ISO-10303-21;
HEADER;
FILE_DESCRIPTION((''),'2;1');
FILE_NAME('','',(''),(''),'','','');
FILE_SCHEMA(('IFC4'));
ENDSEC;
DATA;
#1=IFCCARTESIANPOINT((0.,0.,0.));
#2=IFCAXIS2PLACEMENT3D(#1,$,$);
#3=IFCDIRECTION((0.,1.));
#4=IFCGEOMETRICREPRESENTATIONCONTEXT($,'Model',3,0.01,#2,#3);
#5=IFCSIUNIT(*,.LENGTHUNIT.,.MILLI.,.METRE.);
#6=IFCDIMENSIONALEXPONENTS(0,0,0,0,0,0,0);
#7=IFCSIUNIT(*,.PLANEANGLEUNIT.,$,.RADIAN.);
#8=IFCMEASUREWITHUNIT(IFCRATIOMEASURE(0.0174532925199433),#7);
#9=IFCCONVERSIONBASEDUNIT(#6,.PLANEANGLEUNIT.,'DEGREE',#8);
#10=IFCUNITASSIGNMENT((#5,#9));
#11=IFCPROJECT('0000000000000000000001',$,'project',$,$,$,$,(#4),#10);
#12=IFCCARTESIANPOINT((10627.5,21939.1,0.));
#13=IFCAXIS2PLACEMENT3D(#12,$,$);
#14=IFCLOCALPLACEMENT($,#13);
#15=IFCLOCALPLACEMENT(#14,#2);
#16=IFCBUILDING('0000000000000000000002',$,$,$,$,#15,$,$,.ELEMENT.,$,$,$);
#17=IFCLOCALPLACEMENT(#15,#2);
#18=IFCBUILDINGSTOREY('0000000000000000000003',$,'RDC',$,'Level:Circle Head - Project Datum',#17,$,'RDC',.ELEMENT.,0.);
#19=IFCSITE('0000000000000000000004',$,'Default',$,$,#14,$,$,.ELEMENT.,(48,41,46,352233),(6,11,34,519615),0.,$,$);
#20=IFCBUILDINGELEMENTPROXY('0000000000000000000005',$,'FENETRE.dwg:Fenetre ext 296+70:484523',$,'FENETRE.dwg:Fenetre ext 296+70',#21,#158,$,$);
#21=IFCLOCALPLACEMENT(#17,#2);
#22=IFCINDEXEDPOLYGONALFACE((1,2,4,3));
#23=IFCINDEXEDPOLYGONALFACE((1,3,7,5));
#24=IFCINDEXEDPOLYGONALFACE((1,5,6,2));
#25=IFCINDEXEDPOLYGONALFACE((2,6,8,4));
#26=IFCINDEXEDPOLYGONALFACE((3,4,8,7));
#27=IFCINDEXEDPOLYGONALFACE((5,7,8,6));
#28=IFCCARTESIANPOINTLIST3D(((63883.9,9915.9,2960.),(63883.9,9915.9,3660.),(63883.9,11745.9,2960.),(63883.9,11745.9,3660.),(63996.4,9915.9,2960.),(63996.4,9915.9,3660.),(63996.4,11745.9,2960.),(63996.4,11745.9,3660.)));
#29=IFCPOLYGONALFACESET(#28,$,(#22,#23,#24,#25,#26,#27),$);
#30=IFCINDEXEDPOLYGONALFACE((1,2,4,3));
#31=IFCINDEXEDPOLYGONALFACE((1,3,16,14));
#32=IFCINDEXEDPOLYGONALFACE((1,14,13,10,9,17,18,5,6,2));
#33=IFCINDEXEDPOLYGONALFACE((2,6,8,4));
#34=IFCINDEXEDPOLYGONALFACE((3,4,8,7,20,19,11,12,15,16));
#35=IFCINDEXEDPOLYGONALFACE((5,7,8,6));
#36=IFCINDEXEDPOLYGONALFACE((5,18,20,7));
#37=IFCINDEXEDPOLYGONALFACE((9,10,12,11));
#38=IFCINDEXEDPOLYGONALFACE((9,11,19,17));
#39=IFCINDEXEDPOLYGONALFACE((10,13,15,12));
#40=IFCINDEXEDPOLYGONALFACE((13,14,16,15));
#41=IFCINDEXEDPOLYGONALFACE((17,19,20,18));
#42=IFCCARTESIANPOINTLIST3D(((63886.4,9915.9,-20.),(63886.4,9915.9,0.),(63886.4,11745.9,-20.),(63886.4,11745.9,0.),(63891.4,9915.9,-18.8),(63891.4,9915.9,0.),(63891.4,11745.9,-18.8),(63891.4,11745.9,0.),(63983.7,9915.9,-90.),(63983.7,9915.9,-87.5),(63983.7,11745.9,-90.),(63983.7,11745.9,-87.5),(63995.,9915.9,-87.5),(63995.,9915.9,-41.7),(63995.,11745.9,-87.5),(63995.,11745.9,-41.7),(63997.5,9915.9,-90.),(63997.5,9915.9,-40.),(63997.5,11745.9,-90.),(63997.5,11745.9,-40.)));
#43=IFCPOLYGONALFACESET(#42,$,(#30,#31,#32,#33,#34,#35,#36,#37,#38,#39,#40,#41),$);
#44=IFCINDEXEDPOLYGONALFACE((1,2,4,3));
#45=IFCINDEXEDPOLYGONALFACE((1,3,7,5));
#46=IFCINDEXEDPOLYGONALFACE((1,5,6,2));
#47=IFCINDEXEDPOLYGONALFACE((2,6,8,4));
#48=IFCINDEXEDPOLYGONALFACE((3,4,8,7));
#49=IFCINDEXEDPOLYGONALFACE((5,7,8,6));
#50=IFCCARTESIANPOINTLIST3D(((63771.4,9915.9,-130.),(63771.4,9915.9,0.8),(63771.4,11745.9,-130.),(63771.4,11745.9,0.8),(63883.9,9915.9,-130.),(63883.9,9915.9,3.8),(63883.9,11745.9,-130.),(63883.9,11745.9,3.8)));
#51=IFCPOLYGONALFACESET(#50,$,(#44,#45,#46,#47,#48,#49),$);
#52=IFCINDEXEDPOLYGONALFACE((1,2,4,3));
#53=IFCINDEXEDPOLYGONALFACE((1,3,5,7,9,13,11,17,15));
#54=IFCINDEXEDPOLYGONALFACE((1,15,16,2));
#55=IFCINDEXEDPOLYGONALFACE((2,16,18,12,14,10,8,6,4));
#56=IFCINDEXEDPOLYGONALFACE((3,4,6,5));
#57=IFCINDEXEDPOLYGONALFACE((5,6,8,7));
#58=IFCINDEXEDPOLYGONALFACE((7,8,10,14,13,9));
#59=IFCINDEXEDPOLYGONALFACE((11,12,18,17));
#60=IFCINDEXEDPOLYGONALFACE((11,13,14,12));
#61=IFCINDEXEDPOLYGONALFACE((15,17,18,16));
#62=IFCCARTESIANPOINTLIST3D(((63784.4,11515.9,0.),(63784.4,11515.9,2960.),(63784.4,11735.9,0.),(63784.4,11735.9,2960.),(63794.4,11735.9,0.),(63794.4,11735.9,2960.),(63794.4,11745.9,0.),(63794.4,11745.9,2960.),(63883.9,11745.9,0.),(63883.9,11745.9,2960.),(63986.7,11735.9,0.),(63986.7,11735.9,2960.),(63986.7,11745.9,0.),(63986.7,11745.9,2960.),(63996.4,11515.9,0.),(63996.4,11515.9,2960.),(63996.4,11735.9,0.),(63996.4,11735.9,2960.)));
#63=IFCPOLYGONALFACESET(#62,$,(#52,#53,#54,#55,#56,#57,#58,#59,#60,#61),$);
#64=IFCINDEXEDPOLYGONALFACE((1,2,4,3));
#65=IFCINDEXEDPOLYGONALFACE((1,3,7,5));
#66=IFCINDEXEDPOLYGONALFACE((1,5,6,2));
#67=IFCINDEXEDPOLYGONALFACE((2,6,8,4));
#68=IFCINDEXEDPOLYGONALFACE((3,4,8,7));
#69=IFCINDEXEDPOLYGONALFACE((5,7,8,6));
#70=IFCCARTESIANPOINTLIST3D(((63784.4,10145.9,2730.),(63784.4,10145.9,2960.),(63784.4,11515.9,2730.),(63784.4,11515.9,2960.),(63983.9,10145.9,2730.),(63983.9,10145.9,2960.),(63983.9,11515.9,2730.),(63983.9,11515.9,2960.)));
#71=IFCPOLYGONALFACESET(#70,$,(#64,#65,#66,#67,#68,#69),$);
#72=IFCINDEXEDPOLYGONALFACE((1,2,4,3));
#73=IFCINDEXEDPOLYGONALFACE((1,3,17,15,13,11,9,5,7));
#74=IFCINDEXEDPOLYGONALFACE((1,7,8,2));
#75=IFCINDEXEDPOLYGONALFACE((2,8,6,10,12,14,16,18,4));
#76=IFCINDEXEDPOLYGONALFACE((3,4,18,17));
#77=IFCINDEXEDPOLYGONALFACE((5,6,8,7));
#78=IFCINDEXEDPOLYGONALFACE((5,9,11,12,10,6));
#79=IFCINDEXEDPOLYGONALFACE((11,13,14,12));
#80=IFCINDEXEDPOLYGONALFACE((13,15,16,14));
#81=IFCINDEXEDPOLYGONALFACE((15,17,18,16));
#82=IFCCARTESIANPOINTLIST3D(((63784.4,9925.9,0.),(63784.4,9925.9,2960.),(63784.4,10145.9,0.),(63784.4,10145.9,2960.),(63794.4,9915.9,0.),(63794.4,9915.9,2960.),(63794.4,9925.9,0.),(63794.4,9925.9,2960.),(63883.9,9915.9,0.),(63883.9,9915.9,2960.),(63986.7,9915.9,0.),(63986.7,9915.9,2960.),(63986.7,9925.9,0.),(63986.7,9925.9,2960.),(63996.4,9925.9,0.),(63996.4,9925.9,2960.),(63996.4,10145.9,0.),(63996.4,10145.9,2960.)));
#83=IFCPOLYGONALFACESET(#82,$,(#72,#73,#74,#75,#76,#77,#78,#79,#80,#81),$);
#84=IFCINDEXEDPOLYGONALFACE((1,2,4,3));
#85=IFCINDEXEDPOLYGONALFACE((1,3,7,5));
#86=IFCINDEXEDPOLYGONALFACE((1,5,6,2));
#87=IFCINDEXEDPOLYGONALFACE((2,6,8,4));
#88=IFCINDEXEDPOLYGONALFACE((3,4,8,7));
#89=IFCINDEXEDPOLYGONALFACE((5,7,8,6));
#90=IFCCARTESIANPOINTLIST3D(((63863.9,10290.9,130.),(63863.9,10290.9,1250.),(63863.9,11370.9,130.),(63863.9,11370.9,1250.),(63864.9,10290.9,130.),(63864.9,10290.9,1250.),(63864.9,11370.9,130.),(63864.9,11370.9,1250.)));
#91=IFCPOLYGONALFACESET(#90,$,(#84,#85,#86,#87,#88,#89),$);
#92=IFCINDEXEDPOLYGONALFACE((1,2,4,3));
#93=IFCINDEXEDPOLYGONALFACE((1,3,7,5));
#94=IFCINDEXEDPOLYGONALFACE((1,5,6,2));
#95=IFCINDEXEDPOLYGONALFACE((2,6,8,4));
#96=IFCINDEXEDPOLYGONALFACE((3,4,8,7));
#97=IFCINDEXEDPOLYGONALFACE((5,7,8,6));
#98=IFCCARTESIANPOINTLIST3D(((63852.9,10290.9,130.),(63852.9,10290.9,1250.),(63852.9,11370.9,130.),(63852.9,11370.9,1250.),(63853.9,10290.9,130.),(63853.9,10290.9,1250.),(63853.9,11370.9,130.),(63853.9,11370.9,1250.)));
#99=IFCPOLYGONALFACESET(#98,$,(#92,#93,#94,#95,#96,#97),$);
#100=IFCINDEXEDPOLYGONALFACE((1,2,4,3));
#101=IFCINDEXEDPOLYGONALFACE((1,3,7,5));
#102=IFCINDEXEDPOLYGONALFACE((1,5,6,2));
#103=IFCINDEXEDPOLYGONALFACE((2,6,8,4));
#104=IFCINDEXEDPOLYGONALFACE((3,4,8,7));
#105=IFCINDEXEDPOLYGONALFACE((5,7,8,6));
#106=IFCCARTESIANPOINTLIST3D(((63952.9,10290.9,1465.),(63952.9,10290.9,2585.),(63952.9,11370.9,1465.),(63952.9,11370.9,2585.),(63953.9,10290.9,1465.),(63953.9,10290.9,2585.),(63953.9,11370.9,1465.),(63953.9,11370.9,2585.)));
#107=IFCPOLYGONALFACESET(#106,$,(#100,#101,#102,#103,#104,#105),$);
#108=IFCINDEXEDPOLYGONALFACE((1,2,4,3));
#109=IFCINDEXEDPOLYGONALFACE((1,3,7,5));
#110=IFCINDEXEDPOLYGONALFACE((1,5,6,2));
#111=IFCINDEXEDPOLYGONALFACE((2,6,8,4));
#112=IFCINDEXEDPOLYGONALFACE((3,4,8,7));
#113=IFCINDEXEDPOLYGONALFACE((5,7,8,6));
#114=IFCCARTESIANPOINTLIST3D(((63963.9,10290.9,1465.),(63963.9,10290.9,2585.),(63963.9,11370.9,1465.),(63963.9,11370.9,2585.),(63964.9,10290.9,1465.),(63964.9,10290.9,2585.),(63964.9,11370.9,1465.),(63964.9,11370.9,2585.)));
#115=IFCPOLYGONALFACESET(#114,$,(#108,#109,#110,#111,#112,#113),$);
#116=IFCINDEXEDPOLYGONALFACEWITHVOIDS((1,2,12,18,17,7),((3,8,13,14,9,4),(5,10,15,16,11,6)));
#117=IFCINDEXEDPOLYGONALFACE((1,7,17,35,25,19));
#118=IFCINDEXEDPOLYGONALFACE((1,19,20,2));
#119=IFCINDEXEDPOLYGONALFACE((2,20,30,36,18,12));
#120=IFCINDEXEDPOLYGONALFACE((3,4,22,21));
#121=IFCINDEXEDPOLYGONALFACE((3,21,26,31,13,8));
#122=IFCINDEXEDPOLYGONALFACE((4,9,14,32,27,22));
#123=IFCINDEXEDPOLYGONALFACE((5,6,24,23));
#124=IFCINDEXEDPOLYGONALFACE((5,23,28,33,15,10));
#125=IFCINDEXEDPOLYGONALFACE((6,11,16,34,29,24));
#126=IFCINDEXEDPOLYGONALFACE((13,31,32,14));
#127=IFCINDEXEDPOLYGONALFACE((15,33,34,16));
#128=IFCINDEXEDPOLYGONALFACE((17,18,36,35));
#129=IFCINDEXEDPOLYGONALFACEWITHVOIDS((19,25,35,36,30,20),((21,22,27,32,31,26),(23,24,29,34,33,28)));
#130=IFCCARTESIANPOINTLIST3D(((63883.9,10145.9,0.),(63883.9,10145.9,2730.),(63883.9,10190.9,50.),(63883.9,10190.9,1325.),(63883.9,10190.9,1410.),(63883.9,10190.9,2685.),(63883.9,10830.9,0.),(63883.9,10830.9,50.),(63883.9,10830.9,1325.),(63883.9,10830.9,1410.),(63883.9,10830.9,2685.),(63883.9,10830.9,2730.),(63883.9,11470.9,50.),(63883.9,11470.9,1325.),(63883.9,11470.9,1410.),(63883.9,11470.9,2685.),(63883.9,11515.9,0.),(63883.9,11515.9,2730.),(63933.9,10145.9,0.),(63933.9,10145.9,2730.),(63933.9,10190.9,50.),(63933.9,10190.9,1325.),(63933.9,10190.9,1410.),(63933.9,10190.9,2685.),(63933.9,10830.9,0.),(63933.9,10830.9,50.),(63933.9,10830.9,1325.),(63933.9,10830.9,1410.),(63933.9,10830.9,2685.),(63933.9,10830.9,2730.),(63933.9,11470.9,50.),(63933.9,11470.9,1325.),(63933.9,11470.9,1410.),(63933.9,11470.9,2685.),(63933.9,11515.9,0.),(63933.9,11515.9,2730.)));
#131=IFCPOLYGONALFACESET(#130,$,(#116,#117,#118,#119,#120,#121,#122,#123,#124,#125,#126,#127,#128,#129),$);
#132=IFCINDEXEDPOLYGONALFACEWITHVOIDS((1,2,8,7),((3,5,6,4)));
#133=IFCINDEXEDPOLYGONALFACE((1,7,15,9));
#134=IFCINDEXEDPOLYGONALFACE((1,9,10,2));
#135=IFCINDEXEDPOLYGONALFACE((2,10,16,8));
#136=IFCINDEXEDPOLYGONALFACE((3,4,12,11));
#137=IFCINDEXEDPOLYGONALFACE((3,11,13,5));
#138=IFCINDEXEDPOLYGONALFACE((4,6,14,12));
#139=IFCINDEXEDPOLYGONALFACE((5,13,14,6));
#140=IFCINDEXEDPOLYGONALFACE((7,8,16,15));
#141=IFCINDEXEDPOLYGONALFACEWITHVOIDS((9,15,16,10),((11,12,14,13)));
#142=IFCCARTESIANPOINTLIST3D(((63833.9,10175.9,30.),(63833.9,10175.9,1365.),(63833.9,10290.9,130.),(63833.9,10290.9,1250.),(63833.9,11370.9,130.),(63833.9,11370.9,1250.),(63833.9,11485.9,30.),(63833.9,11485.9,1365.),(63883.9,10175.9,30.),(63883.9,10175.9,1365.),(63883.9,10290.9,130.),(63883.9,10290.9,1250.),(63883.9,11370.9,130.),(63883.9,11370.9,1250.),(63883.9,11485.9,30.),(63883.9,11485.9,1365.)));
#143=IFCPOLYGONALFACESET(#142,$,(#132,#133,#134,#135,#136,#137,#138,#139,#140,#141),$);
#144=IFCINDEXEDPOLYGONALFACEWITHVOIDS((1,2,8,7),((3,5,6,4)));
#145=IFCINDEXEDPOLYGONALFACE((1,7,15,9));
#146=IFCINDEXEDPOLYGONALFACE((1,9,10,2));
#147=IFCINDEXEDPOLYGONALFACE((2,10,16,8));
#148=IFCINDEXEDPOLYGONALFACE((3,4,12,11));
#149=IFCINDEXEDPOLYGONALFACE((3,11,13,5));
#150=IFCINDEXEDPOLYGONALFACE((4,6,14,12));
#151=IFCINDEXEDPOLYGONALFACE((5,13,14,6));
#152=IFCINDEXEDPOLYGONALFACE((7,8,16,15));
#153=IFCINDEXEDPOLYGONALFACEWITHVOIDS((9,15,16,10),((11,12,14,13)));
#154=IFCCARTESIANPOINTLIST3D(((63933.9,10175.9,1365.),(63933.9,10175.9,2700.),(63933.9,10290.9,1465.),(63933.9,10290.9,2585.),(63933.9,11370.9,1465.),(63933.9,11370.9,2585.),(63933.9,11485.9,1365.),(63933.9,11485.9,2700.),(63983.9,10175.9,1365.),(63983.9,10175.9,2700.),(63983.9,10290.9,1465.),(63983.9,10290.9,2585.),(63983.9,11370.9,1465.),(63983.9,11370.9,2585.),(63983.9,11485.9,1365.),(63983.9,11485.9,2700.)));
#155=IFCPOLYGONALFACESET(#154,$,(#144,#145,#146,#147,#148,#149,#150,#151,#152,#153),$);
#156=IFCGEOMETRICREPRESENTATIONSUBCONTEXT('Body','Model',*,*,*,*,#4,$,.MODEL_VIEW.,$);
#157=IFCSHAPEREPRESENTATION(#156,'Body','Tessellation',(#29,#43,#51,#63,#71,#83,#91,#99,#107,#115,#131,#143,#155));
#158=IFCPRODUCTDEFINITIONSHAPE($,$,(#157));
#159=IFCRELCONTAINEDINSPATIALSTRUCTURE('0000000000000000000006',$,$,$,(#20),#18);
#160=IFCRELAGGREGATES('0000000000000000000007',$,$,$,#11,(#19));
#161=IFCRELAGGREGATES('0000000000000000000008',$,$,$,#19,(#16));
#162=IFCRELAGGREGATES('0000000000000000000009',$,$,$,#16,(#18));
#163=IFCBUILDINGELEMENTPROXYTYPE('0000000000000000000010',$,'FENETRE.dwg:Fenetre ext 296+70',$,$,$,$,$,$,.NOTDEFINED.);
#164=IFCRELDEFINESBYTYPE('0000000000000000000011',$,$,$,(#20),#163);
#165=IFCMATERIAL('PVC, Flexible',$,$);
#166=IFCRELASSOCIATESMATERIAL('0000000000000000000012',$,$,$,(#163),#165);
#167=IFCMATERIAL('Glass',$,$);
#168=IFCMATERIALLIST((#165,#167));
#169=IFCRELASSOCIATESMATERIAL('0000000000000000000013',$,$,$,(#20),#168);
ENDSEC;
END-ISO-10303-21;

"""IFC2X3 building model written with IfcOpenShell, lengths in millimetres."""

from ifc_helpers import new_model, entity, si_unit, converted_unit, direction, frame, frame_2d, origin, origin_2d_with_axis, place, context, subcontext, project, spatial, polyline, rectangle, outline, extrude, source, transform, mapped, material, material_list, type_object, type_shapes, element, save


model = new_model("IFC2X3")

# Units and contexts
model_context = context("Model", 3, precision=0.01, world=origin(), true_north=direction((0.0, 1.0)))
body_context = subcontext(model_context, "Body", "Model", "MODEL_VIEW")
ifc_project = project(units=[si_unit("LENGTHUNIT", "METRE", prefix="MILLI"), converted_unit("PLANEANGLEUNIT", "DEGREE", entity("IfcRatioMeasure", 0.0174532925199433), si_unit("PLANEANGLEUNIT", "RADIAN"), dimensions=[0, 0, 0, 0, 0, 0, 0])], contexts=[model_context])

# Site, building, storey
site_placement = place(None, frame((10627.5, 21939.1, 0.0)))
site = spatial("IfcSite", under=ifc_project, at=site_placement, Name="Default", CompositionType="ELEMENT", RefLatitude=(48, 41, 46, 352233), RefLongitude=(6, 11, 34, 519615), RefElevation=0.0)
building_placement = place(site_placement, origin())
building = spatial("IfcBuilding", under=site, at=building_placement, CompositionType="ELEMENT")
storey_placement = place(building_placement, origin())
storey = spatial("IfcBuildingStorey", under=building, at=storey_placement, Name="RDC", ObjectType="Level:Circle Head - Project Datum", LongName="RDC", CompositionType="ELEMENT", Elevation=0.0)

# Building element proxy
ifc_material_1 = material(Name="PVC, Flexible")
ifc_material_2 = material(Name="Glass")
building_element_proxy_type_1 = type_object("IfcBuildingElementProxyType", Name="FENETRE.dwg:Fenetre ext 296+70", PredefinedType="NOTDEFINED", material=ifc_material_1)
shared_shape_1 = source(origin(), body_context, "Body", "SweptSolid", [
    extrude(rectangle(XDim=112.5, YDim=1830.0, at=origin_2d_with_axis()), frame((-10.4, -56.3, 2960.0), z_axis=(0.0, 0.0, 1.0), x_axis=(0.0, 1.0, 0.0)), (0.0, 0.0, 1.0), 700.0),
    extrude(outline(polyline([(27.5, -64.4), (47.5, -64.4), (47.5, -59.4), (28.8, -59.4), (7.5, 46.7), (-42.5, 46.7), (-42.5, 32.9), (-40.0, 32.9), (-40.0, 44.2), (5.8, 44.2), (27.5, -64.4)])), frame((-925.4, -66.9, -47.5), z_axis=(1.0, 0.0, 0.0), x_axis=(0.0, 0.0, 1.0)), (0.0, 0.0, 1.0), 1830.0),
    extrude(outline(polyline([(-54.5, -66.1), (58.0, -66.1), (54.5, 67.6), (-58.0, 64.6), (-54.5, -66.1)])), frame((-925.4, 56.3, -63.8), z_axis=(1.0, 0.0, 0.0), x_axis=(0.0, -0.999645, 0.02665)), (0.0, 0.0, 1.0), 1830.0),
    extrude(outline(polyline([(-97.0, -55.6), (5.9, -55.6), (95.4, -55.6), (95.4, -45.6), (105.4, -45.6), (105.4, 174.4), (-106.6, 174.4), (-106.6, -45.6), (-97.0, -45.6), (-97.0, -55.6)])), frame((849.0, -5.9, 0.0), z_axis=(0.0, 0.0, 1.0), x_axis=(0.0, 1.0, 0.0)), (0.0, 0.0, 1.0), 2960.0),
    extrude(rectangle(XDim=1370.0, YDim=199.5, at=origin_2d_with_axis()), frame((-10.4, -0.3, 2730.0), z_axis=(0.0, 0.0, 1.0), x_axis=(-1.0, 0.0, 0.0)), (0.0, 0.0, 1.0), 230.0),
    extrude(outline(polyline([(-55.6, 97.0), (-55.6, -5.9), (-55.6, -95.4), (-45.6, -95.4), (-45.6, -105.4), (174.4, -105.4), (174.4, 106.6), (-45.6, 106.6), (-45.6, 97.0), (-55.6, 97.0)])), frame((-869.9, -5.9, 0.0), z_axis=(0.0, 0.0, -1.0), x_axis=(1.0, 0.0, 0.0)), (0.0, 0.0, -1.0), 2960.0),
    extrude(rectangle(XDim=1080.0, YDim=1.0, at=origin_2d_with_axis()), frame((-10.4, 19.5, 130.0), z_axis=(0.0, 0.0, 1.0), x_axis=(-1.0, 0.0, 0.0)), (0.0, 0.0, 1.0), 1120.0),
    extrude(rectangle(XDim=1080.0, YDim=1.0, at=origin_2d_with_axis()), frame((-10.4, 30.5, 130.0), z_axis=(0.0, 0.0, 1.0), x_axis=(-1.0, 0.0, 0.0)), (0.0, 0.0, 1.0), 1120.0),
    extrude(rectangle(XDim=1080.0, YDim=1.0, at=frame_2d((0.0, 0.0), x_axis=(1.0, 0.0))), frame((-10.4, -69.5, 1465.0), z_axis=(0.0, 0.0, 1.0), x_axis=(-1.0, 0.0, 0.0)), (0.0, 0.0, 1.0), 1120.0),
    extrude(rectangle(XDim=1080.0, YDim=1.0, at=frame_2d((0.0, 0.0), x_axis=(1.0, 0.0))), frame((-10.4, -80.5, 1465.0), z_axis=(0.0, 0.0, 1.0), x_axis=(-1.0, 0.0, 0.0)), (0.0, 0.0, 1.0), 1120.0),
    extrude(outline(polyline([(-685.0, -1365.0), (0.0, -1365.0), (685.0, -1365.0), (685.0, 1365.0), (0.0, 1365.0), (-685.0, 1365.0), (-685.0, -1365.0)]), holes=[polyline([(-640.0, -1320.0), (-640.0, -45.0), (0.0, -45.0), (640.0, -45.0), (640.0, -1320.0), (0.0, -1320.0), (-640.0, -1320.0)]), polyline([(-640.0, 40.0), (-640.0, 1315.0), (0.0, 1315.0), (640.0, 1315.0), (640.0, 40.0), (0.0, 40.0), (-640.0, 40.0)])]), frame((-10.4, -50.0, 1365.0), z_axis=(0.0, 1.0, 0.0), x_axis=(1.0, 0.0, 0.0)), (0.0, 0.0, 1.0), 50.0),
    extrude(outline(polyline([(-655.0, -667.5), (655.0, -667.5), (655.0, 667.5), (-655.0, 667.5), (-655.0, -667.5)]), holes=[polyline([(-540.0, 552.5), (540.0, 552.5), (540.0, -567.5), (-540.0, -567.5), (-540.0, 552.5)])]), frame((-10.4, 0.0, 697.5), z_axis=(0.0, 1.0, 0.0), x_axis=(-1.0, 0.0, 0.0)), (0.0, 0.0, 1.0), 50.0),
    extrude(outline(polyline([(-655.0, -667.5), (655.0, -667.5), (655.0, 667.5), (-655.0, 667.5), (-655.0, -667.5)]), holes=[polyline([(-540.0, 552.5), (540.0, 552.5), (540.0, -567.5), (-540.0, -567.5), (-540.0, 552.5)])]), frame((-10.4, -100.0, 2032.5), z_axis=(0.0, 1.0, 0.0), x_axis=(-1.0, 0.0, 0.0)), (0.0, 0.0, 1.0), 50.0),
])
type_shapes(building_element_proxy_type_1, [shared_shape_1])
ifc_material_list_1 = material_list([ifc_material_1, ifc_material_2])
proxy_1_placement = place(storey_placement, frame((63883.9, 10841.3, 0.0), z_axis=(0.0, 0.0, 1.0), x_axis=(0.0, 1.0, 0.0)))
element("IfcBuildingElementProxy", 1, at=proxy_1_placement, inside=storey, type_object=building_element_proxy_type_1, material=ifc_material_list_1, Name="FENETRE.dwg:Fenetre ext 296+70:484523", ObjectType="FENETRE.dwg:Fenetre ext 296+70", context=body_context, shape_type="MappedRepresentation", body=[
    mapped(shared_shape_1, transform((0.0, 0.0, 0.0), scale=1.0)),
])

save(model, "model.ifc")
